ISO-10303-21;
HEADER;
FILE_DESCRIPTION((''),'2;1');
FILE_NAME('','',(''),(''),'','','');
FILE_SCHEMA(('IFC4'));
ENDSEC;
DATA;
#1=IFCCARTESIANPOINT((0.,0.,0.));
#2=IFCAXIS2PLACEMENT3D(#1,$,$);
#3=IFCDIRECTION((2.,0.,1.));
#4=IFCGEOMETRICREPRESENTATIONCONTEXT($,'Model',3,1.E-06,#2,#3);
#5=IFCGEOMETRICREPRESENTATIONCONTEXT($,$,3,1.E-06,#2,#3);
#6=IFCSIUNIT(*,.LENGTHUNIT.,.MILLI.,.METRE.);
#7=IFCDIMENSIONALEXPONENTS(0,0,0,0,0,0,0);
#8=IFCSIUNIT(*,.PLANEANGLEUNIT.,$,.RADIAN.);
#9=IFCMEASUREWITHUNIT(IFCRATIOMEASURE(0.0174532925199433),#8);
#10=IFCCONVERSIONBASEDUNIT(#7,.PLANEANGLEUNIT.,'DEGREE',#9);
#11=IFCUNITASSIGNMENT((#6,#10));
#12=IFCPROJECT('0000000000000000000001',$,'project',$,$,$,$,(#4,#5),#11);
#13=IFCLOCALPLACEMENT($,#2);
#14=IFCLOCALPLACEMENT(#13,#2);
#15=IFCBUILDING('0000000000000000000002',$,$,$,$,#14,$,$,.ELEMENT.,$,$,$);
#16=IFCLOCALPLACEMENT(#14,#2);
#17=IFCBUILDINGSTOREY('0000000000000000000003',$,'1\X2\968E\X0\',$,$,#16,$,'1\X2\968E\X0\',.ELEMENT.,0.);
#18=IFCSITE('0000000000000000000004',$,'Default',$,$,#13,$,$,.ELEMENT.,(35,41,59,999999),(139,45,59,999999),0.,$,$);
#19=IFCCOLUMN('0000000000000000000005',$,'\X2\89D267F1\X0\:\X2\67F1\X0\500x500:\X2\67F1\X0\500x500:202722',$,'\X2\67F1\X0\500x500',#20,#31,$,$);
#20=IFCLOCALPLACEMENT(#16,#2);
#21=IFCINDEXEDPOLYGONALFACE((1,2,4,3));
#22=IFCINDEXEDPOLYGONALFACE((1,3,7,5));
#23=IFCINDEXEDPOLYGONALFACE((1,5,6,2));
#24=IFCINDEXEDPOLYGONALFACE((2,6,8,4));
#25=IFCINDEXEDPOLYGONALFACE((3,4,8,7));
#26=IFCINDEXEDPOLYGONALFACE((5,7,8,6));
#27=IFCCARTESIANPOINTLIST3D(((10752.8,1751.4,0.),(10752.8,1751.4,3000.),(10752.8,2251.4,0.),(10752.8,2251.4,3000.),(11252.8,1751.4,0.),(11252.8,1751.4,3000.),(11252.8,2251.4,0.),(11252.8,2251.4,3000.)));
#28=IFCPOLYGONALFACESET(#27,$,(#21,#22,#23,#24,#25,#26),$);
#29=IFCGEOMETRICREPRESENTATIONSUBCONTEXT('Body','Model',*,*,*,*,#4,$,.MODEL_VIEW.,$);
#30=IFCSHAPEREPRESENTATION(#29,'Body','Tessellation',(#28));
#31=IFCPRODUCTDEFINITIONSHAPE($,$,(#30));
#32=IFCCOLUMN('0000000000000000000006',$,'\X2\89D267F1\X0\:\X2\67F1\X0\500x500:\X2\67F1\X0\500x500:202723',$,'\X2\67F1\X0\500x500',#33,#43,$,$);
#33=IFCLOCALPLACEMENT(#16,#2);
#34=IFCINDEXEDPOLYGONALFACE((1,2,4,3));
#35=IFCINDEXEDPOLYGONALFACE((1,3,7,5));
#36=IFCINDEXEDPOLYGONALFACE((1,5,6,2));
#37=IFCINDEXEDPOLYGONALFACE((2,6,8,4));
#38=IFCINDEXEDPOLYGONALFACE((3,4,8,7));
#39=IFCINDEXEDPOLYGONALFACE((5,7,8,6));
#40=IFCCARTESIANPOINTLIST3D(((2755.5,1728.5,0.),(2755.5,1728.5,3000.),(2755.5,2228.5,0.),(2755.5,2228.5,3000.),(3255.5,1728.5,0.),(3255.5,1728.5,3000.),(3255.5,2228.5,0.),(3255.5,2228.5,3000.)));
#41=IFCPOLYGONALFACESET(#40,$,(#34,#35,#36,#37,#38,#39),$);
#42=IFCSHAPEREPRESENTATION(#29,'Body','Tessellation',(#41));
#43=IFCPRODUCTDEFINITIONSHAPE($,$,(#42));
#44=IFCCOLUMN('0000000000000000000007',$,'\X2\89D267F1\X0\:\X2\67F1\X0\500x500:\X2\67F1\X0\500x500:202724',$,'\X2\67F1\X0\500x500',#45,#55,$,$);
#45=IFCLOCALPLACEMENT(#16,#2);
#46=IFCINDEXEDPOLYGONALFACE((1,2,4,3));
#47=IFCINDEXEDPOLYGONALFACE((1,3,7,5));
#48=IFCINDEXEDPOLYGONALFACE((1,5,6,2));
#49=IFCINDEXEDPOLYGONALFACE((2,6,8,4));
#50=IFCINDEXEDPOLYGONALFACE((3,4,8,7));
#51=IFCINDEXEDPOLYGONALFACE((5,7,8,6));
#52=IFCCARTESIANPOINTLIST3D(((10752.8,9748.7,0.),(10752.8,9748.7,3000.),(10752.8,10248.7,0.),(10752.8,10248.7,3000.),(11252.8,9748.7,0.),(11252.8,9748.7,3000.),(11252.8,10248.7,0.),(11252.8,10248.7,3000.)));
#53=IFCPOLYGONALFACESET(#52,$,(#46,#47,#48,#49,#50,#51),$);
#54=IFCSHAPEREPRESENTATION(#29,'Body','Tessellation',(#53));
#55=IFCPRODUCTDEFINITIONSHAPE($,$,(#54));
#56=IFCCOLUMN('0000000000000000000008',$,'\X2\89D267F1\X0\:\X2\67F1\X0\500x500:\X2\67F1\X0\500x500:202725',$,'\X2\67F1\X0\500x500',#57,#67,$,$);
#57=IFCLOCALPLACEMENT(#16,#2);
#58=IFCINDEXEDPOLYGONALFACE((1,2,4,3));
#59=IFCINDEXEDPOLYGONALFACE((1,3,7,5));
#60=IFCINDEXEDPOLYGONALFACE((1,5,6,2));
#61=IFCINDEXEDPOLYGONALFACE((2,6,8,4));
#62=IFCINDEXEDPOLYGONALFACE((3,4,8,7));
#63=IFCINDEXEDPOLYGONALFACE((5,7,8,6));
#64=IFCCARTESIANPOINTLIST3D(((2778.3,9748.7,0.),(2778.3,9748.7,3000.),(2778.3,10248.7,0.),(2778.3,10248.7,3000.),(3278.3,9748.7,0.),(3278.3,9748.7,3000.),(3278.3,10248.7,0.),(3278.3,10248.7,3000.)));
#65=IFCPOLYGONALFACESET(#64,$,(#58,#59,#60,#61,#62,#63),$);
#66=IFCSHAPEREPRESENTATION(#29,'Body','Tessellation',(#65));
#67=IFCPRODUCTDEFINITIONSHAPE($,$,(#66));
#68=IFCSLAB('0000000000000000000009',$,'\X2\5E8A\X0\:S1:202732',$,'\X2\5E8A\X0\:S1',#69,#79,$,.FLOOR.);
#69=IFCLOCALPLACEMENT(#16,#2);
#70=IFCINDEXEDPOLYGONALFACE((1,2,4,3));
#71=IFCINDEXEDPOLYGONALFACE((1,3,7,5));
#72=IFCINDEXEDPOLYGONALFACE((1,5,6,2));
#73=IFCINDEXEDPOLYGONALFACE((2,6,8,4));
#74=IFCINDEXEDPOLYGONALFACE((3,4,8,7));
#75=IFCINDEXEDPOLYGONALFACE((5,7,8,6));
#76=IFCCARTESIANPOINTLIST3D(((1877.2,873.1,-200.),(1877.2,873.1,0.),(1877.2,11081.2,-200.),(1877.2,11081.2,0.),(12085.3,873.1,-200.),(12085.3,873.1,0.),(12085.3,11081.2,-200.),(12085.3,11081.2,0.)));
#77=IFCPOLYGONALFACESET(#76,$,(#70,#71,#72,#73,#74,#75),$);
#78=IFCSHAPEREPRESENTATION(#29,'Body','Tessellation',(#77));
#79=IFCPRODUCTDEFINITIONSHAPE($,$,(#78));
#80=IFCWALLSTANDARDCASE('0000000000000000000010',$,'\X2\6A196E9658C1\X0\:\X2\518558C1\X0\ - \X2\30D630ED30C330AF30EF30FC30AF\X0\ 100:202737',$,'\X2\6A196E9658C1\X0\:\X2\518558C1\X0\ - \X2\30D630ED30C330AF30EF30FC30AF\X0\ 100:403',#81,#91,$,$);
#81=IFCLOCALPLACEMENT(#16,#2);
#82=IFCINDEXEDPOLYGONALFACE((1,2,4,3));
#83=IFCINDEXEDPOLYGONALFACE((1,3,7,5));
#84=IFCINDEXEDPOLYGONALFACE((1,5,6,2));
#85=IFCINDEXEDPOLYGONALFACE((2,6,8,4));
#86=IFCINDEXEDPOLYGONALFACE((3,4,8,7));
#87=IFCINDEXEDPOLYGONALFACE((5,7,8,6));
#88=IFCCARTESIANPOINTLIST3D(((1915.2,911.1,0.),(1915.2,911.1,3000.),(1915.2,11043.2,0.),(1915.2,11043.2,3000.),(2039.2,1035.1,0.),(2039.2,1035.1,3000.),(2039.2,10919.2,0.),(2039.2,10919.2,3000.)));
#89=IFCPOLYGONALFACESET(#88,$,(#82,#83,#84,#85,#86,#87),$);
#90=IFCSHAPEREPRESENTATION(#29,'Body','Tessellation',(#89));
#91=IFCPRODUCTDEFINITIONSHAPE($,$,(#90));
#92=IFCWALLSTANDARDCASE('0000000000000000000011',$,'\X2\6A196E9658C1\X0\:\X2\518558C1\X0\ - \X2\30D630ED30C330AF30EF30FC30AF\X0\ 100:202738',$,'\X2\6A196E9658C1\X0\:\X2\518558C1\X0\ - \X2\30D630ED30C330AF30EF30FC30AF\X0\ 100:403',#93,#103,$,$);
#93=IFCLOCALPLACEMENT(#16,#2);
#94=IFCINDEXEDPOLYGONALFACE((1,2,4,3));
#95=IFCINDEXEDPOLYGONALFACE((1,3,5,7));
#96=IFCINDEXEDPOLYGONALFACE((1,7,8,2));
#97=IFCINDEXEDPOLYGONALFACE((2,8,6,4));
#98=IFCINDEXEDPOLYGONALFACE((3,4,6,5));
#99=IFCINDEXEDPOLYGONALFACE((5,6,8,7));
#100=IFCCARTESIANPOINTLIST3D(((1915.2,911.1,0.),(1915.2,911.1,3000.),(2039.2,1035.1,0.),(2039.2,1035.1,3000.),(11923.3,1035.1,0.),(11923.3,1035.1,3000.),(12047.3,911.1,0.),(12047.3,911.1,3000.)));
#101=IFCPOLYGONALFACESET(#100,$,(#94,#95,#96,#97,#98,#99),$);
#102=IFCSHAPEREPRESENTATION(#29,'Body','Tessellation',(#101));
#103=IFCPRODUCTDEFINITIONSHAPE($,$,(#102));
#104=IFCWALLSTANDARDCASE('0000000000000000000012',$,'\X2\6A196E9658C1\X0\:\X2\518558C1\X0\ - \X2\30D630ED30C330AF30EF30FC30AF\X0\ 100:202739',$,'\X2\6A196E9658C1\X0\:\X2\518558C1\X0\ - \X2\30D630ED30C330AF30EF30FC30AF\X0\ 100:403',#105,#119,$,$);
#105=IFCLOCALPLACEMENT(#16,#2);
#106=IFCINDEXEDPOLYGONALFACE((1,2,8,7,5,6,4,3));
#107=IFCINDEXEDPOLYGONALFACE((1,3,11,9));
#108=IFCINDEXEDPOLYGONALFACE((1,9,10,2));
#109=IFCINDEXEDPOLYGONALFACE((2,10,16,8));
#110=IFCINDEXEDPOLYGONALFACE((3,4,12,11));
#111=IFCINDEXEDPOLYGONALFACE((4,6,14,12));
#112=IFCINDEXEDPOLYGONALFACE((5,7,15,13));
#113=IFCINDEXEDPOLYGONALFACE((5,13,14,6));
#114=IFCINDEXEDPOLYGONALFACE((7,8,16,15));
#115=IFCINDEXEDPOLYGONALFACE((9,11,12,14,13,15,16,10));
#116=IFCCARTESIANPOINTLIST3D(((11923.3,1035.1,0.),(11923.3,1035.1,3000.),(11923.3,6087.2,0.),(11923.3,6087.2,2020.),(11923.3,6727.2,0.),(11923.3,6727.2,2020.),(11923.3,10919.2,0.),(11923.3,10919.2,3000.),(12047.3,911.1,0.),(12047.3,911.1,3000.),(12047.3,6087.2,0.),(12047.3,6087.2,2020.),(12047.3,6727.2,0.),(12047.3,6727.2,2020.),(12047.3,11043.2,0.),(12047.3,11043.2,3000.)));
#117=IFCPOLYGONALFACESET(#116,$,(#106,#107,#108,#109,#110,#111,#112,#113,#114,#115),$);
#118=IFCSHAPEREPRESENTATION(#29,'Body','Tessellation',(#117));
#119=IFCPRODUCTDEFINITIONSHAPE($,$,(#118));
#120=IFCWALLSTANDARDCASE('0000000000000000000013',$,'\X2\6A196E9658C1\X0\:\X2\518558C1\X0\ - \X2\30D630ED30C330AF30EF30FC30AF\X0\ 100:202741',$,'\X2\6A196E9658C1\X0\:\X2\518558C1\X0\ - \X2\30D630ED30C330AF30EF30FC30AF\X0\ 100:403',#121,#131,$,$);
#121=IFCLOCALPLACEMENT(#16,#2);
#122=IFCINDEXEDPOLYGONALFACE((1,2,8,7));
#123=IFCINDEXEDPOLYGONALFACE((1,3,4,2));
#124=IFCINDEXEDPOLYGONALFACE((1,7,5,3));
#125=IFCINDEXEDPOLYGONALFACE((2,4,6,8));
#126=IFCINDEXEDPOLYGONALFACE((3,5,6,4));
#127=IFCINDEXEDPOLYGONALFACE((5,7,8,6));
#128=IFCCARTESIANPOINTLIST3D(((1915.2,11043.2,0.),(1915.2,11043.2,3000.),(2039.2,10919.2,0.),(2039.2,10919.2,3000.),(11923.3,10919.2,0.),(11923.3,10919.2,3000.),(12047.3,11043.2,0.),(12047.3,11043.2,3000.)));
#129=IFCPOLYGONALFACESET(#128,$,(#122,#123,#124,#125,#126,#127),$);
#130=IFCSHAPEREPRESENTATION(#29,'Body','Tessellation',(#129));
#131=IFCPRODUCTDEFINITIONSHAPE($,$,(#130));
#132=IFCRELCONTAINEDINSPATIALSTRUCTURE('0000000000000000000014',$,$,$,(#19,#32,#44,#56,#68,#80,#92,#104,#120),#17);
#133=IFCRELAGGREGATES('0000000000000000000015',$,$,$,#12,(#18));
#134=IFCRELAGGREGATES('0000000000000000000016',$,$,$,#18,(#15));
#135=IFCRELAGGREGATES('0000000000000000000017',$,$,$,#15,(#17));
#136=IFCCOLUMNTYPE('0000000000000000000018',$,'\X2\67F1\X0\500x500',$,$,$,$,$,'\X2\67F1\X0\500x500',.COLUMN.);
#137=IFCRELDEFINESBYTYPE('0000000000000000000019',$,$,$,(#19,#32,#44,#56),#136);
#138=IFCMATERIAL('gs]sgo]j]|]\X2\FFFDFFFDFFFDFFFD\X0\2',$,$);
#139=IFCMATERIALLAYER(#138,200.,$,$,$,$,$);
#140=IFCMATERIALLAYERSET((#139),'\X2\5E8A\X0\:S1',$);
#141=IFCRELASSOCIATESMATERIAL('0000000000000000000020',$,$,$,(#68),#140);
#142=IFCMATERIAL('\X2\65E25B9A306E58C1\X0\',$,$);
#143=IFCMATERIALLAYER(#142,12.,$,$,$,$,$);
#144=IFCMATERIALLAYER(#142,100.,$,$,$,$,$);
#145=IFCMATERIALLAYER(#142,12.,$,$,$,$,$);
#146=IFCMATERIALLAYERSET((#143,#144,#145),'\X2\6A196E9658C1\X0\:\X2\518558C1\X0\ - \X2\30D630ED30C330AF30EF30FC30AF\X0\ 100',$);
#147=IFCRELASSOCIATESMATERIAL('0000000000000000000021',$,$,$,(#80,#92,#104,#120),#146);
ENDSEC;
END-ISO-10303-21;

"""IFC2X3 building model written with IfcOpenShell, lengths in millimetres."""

from ifc_helpers import new_model, entity, si_unit, converted_unit, direction, frame, frame_2d, origin, place, context, subcontext, project, spatial, polyline, rectangle, outline, extrude, source, transform, mapped, material, layer, layer_set, layer_usage, type_object, type_shapes, element, save


model = new_model("IFC2X3")

# Units and contexts
model_context = context("Model", 3, precision=1e-06, world=origin(), true_north=direction((2.0, 0.0, 1.0)))
context_of_model = context(None, 3, precision=1e-06, world=origin(), true_north=direction((2.0, 0.0, 1.0)))
body_context = subcontext(model_context, "Body", "Model", "MODEL_VIEW")
ifc_project = project(units=[si_unit("LENGTHUNIT", "METRE", prefix="MILLI"), converted_unit("PLANEANGLEUNIT", "DEGREE", entity("IfcRatioMeasure", 0.0174532925199433), si_unit("PLANEANGLEUNIT", "RADIAN"), dimensions=[0, 0, 0, 0, 0, 0, 0])], contexts=[model_context, context_of_model])

# Site, building, storey
site_placement = place(None, origin())
site = spatial("IfcSite", under=ifc_project, at=site_placement, Name="Default", CompositionType="ELEMENT", RefLatitude=(35, 41, 59, 999999), RefLongitude=(139, 45, 59, 999999), RefElevation=0.0)
building_placement = place(site_placement, origin())
building = spatial("IfcBuilding", under=site, at=building_placement, CompositionType="ELEMENT")
storey_placement = place(building_placement, origin())
storey = spatial("IfcBuildingStorey", under=building, at=storey_placement, Name="1階", LongName="1階", CompositionType="ELEMENT", Elevation=0.0)

# Columns
column_type = type_object("IfcColumnType", Name="柱500x500", ElementType="柱500x500", PredefinedType="COLUMN")
shared_shape = source(origin(), body_context, "Body", "SweptSolid", [
    extrude(rectangle(XDim=500.0, YDim=500.0, at=frame_2d((0.0, 0.0), x_axis=(0.0, -1.0))), origin(), (0.0, 0.0, 1.0), 3000.0),
])
type_shapes(column_type, [shared_shape])
for number, where, name in (
    (1, (11002.8, 2001.4, 0.0), "角柱:柱500x500:柱500x500:202722"),
    (2, (3005.5, 1978.5, 0.0), "角柱:柱500x500:柱500x500:202723"),
    (3, (11002.8, 9998.7, 0.0), "角柱:柱500x500:柱500x500:202724"),
    (4, (3028.3, 9998.7, 0.0), "角柱:柱500x500:柱500x500:202725"),
):
    element("IfcColumn", number, at=place(storey_placement, frame(where)), inside=storey, type_object=column_type, Name=name, ObjectType="柱500x500", context=body_context, shape_type="MappedRepresentation", body=[
        mapped(shared_shape, transform((0.0, 0.0, 0.0), scale=1.0)),
    ])

# Slab
ifc_material_1 = material(Name="gs]sgo]j]|]����2")
ifc_layer_1 = layer(ifc_material_1, 200.0)
ifc_layer_set_1 = layer_set([ifc_layer_1], Name="床:S1")
ifc_layer_usage_1 = layer_usage(ifc_layer_set_1, "AXIS3", "POSITIVE", 0.0)
slab_placement = place(storey_placement, frame((1877.2, 873.1, -200.0)))
element("IfcSlab", 5, at=slab_placement, inside=storey, material=ifc_layer_usage_1, Name="床:S1:202732", ObjectType="床:S1", PredefinedType="FLOOR", context=body_context, shape_type="SweptSolid", body=[
    extrude(rectangle(XDim=10208.1, YDim=10208.1, at=frame_2d((0.0, 0.0), x_axis=(0.0, -1.0))), frame((5104.0, 5104.0, 200.0), z_axis=(0.0, 0.0, -1.0), x_axis=(-1.0, 0.0, 0.0)), (0.0, 0.0, 1.0), 200.0),
])

# Walls
ifc_material_2 = material(Name="既定の壁")
ifc_layer_2 = layer(ifc_material_2, 12.0)
ifc_layer_3 = layer(ifc_material_2, 100.0)
ifc_layer_4 = layer(ifc_material_2, 12.0)
ifc_layer_set_2 = layer_set([ifc_layer_2, ifc_layer_3, ifc_layer_4], Name="標準壁:内壁 - ブロックワーク 100")
ifc_layer_usage_2 = layer_usage(ifc_layer_set_2, "AXIS2", "NEGATIVE", 62.0)
wall_1_placement = place(storey_placement, frame((1977.2, 11043.2, 0.0), z_axis=(0.0, 0.0, 1.0), x_axis=(0.0, -1.0, 0.0)))
element("IfcWallStandardCase", 6, at=wall_1_placement, inside=storey, material=ifc_layer_usage_2, Name="標準壁:内壁 - ブロックワーク 100:202737", ObjectType="標準壁:内壁 - ブロックワーク 100:403", context=body_context, shape_type="SweptSolid", body=[
    extrude(outline(polyline([(10132.1, -62.0), (10008.1, 62.0), (124.0, 62.0), (0.0, -62.0), (10132.1, -62.0)])), origin(), (0.0, 0.0, 1.0), 3000.0),
])
ifc_layer_usage_3 = layer_usage(ifc_layer_set_2, "AXIS2", "NEGATIVE", 62.0)
wall_2_placement = place(storey_placement, frame((1915.2, 973.1, 0.0)))
element("IfcWallStandardCase", 7, at=wall_2_placement, inside=storey, material=ifc_layer_usage_3, Name="標準壁:内壁 - ブロックワーク 100:202738", ObjectType="標準壁:内壁 - ブロックワーク 100:403", context=body_context, shape_type="SweptSolid", body=[
    extrude(outline(polyline([(10132.1, -62.0), (10008.1, 62.0), (124.0, 62.0), (0.0, -62.0), (10132.1, -62.0)])), origin(), (0.0, 0.0, 1.0), 3000.0),
])

# Wall, opening
ifc_layer_usage_4 = layer_usage(ifc_layer_set_2, "AXIS2", "NEGATIVE", 62.0)
wall_3_placement = place(storey_placement, frame((11985.3, 911.1, 0.0), z_axis=(0.0, 0.0, 1.0), x_axis=(0.0, 1.0, 0.0)))
wall_3 = element("IfcWallStandardCase", 8, at=wall_3_placement, inside=storey, material=ifc_layer_usage_4, Name="標準壁:内壁 - ブロックワーク 100:202739", ObjectType="標準壁:内壁 - ブロックワーク 100:403", context=body_context, shape_type="SweptSolid", body=[
    extrude(outline(polyline([(0.0, -62.0), (10132.1, -62.0), (10008.1, 62.0), (124.0, 62.0), (0.0, -62.0)])), origin(), (0.0, 0.0, 1.0), 3000.0),
])
opening_placement = place(wall_3_placement, frame((5816.1, 62.0, 0.0)))
element("IfcOpeningElement", 9, at=opening_placement, cuts=wall_3, ObjectType="Opening", context=body_context, shape_type="SweptSolid", body=[
    extrude(rectangle(XDim=2020.0, YDim=640.0, at=frame_2d((1010.0, 320.0), x_axis=(-1.0, 0.0))), frame((0.0, 0.0, 0.0), z_axis=(0.0, -1.0, 0.0), x_axis=(0.0, 0.0, 1.0)), (0.0, 0.0, 1.0), 124.0),
])

# Wall
ifc_layer_usage_5 = layer_usage(ifc_layer_set_2, "AXIS2", "NEGATIVE", 62.0)
wall_4_placement = place(storey_placement, frame((12047.3, 10981.2, 0.0), z_axis=(0.0, 0.0, 1.0), x_axis=(-1.0, 0.0, 0.0)))
element("IfcWallStandardCase", 10, at=wall_4_placement, inside=storey, material=ifc_layer_usage_5, Name="標準壁:内壁 - ブロックワーク 100:202741", ObjectType="標準壁:内壁 - ブロックワーク 100:403", context=body_context, shape_type="SweptSolid", body=[
    extrude(outline(polyline([(10132.1, -62.0), (10008.1, 62.0), (124.0, 62.0), (0.0, -62.0), (10132.1, -62.0)])), origin(), (0.0, 0.0, 1.0), 3000.0),
])

save(model, "model.ifc")
